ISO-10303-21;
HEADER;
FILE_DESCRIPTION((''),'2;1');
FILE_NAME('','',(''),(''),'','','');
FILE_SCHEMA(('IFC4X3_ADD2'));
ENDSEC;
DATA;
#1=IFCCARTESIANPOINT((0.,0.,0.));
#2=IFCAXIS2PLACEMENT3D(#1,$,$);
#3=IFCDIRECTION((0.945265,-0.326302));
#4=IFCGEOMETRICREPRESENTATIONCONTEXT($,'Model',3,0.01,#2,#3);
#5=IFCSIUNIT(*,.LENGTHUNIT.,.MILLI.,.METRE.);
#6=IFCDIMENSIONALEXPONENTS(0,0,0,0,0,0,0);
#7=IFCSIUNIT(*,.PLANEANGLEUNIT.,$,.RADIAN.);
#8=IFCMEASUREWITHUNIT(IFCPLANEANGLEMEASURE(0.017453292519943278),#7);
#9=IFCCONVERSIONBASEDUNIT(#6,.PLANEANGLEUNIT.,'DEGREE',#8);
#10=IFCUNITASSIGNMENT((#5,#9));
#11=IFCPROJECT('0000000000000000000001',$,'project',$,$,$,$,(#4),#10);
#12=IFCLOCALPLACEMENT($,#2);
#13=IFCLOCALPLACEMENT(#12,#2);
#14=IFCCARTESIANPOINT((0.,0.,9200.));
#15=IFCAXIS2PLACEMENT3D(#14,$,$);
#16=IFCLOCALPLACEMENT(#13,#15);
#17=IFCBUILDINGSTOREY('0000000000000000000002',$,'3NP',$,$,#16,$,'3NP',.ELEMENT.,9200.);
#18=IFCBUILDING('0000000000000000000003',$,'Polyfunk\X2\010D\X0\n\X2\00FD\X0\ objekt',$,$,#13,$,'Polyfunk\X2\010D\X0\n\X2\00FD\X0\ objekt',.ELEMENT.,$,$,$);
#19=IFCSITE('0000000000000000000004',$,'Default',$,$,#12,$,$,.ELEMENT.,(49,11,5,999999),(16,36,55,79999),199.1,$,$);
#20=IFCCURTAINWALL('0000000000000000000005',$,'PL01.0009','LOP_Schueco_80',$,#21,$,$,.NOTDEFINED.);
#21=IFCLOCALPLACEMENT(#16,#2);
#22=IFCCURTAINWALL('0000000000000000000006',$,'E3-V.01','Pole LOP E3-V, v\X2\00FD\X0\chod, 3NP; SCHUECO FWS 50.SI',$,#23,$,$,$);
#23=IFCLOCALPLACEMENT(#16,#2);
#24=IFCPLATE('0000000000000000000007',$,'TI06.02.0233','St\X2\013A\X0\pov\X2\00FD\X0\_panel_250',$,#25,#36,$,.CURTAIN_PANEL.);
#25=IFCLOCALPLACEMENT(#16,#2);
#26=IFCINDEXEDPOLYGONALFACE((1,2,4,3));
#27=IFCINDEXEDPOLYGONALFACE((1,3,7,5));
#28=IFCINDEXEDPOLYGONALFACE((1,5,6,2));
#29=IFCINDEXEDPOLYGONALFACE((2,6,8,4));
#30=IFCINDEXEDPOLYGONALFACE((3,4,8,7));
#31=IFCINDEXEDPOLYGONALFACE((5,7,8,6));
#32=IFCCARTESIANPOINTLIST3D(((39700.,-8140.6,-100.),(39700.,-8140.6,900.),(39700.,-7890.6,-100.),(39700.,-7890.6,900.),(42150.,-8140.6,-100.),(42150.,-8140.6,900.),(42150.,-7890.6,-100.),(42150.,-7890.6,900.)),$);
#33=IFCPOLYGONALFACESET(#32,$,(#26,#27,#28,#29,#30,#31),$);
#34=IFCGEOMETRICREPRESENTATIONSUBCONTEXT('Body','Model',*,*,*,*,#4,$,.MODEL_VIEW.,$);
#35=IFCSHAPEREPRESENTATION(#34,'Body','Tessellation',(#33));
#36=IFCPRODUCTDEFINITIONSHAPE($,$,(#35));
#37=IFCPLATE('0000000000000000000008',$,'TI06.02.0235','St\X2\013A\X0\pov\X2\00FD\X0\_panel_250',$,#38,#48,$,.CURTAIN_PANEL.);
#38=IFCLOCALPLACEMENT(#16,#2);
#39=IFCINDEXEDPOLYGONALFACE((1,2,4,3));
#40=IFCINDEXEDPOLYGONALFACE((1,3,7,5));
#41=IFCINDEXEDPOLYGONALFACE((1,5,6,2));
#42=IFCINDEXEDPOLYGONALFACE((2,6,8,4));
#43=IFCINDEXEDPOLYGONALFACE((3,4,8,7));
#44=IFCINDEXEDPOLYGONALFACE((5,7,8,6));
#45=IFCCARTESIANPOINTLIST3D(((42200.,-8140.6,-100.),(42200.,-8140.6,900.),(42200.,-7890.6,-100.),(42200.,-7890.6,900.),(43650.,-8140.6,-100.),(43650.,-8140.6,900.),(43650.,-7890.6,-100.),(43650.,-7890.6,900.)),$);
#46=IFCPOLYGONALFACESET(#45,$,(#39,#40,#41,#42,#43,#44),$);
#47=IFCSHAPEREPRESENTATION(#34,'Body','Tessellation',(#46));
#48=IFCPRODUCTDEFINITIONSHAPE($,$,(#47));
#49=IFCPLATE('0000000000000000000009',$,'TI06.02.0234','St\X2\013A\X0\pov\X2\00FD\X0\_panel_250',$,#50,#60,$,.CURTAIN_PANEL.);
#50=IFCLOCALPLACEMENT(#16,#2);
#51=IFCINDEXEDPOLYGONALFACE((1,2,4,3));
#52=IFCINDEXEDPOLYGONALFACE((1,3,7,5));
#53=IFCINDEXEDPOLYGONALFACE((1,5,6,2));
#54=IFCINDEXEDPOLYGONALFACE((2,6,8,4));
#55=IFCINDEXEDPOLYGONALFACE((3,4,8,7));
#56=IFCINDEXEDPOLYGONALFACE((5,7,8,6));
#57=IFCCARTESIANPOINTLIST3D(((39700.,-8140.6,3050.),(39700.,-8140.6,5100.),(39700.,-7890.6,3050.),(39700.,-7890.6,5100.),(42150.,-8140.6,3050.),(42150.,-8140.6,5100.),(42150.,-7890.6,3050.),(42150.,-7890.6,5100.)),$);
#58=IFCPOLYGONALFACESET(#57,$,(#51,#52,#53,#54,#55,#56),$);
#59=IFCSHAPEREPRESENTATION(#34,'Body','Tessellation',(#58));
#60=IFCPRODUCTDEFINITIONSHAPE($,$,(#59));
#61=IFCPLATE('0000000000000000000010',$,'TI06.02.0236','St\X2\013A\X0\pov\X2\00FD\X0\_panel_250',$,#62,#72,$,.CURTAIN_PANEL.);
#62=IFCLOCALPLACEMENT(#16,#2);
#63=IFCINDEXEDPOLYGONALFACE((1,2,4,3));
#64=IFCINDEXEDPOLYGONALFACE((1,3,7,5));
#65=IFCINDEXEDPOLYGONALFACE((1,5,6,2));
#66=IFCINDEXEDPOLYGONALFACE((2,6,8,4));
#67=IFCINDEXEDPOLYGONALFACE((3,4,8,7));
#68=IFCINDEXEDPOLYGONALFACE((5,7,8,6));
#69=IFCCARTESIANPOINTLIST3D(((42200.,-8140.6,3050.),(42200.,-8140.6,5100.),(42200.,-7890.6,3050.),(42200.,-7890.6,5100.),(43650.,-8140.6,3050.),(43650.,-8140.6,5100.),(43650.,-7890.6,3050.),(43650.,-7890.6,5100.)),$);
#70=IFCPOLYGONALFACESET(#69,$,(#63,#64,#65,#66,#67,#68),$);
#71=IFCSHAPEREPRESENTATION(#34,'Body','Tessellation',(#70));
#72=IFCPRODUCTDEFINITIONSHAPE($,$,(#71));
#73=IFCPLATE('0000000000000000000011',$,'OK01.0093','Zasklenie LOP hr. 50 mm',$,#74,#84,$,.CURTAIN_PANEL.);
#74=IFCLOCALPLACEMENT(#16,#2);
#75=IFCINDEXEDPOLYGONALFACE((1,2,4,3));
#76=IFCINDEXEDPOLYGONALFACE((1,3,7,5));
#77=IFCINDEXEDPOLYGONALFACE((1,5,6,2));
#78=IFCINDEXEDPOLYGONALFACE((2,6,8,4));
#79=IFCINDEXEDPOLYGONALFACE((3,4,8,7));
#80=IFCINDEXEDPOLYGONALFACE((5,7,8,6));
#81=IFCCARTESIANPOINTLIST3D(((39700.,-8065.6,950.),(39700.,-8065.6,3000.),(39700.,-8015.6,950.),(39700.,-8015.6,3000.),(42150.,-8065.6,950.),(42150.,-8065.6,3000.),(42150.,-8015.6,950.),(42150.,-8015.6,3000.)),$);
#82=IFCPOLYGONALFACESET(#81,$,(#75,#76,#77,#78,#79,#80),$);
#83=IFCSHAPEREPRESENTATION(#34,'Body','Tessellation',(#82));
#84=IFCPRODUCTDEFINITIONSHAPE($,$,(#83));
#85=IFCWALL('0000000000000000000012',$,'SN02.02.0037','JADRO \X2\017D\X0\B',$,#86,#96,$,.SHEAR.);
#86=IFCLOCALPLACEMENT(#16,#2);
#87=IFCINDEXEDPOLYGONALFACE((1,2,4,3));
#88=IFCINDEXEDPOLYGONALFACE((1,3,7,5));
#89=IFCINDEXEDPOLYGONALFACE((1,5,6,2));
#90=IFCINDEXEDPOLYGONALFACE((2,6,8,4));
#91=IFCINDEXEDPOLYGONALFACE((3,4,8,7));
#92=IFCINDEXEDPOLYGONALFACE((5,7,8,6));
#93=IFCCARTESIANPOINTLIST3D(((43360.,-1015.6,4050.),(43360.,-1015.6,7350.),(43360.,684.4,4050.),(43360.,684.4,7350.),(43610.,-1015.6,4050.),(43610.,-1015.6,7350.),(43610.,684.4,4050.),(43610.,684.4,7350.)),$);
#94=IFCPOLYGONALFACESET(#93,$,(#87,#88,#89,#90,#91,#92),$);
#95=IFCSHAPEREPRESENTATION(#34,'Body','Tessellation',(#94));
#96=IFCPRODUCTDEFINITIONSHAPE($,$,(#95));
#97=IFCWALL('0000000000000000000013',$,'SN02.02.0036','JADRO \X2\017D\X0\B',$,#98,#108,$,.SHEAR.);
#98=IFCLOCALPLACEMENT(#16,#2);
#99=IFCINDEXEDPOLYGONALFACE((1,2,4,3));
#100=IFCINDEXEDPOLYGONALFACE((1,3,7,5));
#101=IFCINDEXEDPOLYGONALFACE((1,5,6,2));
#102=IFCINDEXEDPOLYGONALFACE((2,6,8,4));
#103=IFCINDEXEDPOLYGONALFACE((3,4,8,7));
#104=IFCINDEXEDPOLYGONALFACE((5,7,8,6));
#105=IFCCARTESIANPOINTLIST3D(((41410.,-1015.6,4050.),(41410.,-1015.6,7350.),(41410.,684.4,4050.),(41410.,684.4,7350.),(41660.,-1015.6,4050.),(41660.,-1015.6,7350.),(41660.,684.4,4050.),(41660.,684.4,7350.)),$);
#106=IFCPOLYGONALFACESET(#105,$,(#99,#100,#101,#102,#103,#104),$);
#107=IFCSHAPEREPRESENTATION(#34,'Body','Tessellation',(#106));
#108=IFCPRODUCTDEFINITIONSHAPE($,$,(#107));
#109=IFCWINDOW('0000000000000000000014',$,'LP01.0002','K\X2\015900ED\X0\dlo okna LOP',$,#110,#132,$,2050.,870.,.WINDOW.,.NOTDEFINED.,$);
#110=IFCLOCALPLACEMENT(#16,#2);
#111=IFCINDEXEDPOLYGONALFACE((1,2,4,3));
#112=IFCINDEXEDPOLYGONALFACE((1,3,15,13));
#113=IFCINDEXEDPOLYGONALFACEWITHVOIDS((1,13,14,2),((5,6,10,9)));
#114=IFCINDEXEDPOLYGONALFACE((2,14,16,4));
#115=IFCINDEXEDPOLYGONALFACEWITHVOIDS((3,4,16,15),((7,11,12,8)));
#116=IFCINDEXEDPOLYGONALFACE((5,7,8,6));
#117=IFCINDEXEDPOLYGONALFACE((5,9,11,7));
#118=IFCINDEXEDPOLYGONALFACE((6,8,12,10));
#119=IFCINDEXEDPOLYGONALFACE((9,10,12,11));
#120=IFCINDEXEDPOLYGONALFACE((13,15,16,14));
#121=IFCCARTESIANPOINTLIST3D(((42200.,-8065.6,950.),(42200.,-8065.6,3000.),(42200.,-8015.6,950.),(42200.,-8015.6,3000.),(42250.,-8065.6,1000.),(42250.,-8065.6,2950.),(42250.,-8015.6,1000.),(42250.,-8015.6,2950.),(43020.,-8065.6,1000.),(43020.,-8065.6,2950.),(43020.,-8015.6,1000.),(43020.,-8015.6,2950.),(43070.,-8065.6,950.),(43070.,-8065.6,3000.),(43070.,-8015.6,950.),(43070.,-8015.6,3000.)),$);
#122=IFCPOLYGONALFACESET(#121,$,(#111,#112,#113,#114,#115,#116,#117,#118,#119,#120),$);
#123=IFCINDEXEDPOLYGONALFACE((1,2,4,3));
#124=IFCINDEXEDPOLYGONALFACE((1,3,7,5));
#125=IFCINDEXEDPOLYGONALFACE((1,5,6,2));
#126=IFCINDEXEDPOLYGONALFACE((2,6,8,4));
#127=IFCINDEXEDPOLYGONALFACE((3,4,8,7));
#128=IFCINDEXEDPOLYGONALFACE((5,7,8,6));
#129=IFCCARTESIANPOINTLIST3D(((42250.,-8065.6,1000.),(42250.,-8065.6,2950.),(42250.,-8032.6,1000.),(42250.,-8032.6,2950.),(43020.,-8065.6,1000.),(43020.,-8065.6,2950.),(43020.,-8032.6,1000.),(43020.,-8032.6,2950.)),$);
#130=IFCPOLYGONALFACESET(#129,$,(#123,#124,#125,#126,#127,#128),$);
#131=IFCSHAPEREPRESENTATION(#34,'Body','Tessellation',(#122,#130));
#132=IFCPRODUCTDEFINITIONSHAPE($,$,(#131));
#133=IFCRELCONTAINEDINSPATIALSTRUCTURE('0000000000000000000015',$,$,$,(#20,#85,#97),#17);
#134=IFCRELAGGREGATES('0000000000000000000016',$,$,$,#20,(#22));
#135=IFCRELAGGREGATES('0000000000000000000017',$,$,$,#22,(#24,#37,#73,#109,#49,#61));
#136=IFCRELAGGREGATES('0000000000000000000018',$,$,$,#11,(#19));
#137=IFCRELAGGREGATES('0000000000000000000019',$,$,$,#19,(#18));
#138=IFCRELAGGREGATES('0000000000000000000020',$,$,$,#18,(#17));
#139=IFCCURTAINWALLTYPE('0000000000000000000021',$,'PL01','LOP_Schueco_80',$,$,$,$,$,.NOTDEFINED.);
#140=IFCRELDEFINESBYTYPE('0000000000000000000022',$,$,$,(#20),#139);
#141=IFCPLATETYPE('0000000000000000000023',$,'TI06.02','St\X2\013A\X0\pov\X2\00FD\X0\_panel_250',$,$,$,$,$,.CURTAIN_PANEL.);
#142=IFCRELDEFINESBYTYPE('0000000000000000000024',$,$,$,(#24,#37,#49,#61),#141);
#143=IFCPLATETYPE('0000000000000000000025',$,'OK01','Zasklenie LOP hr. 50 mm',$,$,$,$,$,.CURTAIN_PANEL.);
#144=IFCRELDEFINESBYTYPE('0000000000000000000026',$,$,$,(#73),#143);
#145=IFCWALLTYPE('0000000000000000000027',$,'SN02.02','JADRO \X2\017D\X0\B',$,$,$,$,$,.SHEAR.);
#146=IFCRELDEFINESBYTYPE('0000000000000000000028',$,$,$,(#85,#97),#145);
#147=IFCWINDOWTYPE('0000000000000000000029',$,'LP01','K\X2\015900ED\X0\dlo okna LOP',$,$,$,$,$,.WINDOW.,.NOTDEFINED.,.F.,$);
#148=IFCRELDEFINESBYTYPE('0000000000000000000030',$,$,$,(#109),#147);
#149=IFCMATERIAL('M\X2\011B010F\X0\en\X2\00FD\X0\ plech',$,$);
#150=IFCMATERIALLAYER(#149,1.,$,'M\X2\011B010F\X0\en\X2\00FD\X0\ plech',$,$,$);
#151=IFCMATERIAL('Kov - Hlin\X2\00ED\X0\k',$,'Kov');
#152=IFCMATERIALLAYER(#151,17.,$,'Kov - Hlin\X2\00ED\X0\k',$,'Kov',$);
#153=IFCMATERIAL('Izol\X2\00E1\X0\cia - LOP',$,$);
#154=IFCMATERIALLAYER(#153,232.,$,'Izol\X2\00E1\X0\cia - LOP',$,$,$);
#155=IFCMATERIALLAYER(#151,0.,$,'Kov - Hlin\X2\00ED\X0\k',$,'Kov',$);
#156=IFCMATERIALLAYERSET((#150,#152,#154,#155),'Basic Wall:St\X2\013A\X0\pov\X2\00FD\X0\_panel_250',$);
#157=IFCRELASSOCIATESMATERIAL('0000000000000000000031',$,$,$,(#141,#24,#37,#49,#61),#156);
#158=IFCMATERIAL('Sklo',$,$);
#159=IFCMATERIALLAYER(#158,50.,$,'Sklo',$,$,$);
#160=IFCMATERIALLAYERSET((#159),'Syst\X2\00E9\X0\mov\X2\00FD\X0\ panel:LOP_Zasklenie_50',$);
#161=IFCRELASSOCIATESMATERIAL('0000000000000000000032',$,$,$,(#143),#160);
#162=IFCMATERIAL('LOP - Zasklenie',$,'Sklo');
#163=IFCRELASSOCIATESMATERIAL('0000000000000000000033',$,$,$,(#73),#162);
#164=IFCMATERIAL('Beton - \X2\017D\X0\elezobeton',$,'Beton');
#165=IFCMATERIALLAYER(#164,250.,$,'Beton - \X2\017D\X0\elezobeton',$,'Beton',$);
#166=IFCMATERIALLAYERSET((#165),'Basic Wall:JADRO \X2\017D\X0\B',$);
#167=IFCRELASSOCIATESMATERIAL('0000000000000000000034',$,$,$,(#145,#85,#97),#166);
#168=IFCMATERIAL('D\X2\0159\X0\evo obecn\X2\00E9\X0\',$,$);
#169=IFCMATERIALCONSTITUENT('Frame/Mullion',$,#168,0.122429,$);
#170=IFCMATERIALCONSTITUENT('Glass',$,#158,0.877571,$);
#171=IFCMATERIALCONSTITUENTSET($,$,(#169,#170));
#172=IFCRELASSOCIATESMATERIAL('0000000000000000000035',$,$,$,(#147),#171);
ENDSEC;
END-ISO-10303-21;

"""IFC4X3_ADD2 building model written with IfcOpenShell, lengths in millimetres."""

from ifc_helpers import new_model, entity, si_unit, converted_unit, direction, frame, frame_2d, origin, origin_2d_with_axis, place, context, subcontext, project, spatial, polyline, rectangle, outline, extrude, clip, bounded_halfspace, source, transform, mapped, material, layer, layer_set, layer_usage, constituent, constituent_set, type_object, type_shapes, element, aggregate, save


model = new_model("IFC4X3_ADD2")

# Units and contexts
model_context = context("Model", 3, precision=0.01, world=origin(), true_north=direction((0.945265, -0.326302)))
body_context = subcontext(model_context, "Body", "Model", "MODEL_VIEW")
ifc_project = project(units=[si_unit("LENGTHUNIT", "METRE", prefix="MILLI"), converted_unit("PLANEANGLEUNIT", "DEGREE", entity("IfcPlaneAngleMeasure", 0.017453292519943278), si_unit("PLANEANGLEUNIT", "RADIAN"), dimensions=[0, 0, 0, 0, 0, 0, 0])], contexts=[model_context])

# Site, building, storey
site_placement = place(None, origin())
site = spatial("IfcSite", under=ifc_project, at=site_placement, Name="Default", CompositionType="ELEMENT", RefLatitude=(49, 11, 5, 999999), RefLongitude=(16, 36, 55, 79999), RefElevation=199.1)
building_placement = place(site_placement, origin())
building = spatial("IfcBuilding", under=site, at=building_placement, Name="Polyfunkčný objekt", LongName="Polyfunkčný objekt", CompositionType="ELEMENT")
storey_placement = place(building_placement, frame((0.0, 0.0, 9200.0)))
storey = spatial("IfcBuildingStorey", under=building, at=storey_placement, Name="3NP", LongName="3NP", CompositionType="ELEMENT", Elevation=9200.0)

# Curtain walls, plates
curtain_wall_type = type_object("IfcCurtainWallType", Name="PL01", Description="LOP_Schueco_80", PredefinedType="NOTDEFINED")
curtain_wall_1_placement = place(storey_placement, frame((0.0, 0.0, -9200.0)))
curtain_wall_1 = element("IfcCurtainWall", 1, at=curtain_wall_1_placement, inside=storey, type_object=curtain_wall_type, Name="PL01.0009", Description="LOP_Schueco_80", PredefinedType="NOTDEFINED")
curtain_wall_2 = element("IfcCurtainWall", 2, Name="E3-V.01", Description="Pole LOP E3-V, východ, 3NP; SCHUECO FWS 50.SI")
aggregate(curtain_wall_1, [curtain_wall_2])
ifc_material_1 = material(Name="Měďený plech")
ifc_layer_1 = layer(ifc_material_1, 1.0, Name="Měďený plech")
ifc_material_2 = material(Name="Kov - Hliník", Category="Kov")
ifc_layer_2 = layer(ifc_material_2, 17.0, Name="Kov - Hliník", Category="Kov")
ifc_material_3 = material(Name="Izolácia - LOP")
ifc_layer_3 = layer(ifc_material_3, 232.0, Name="Izolácia - LOP")
ifc_layer_4 = layer(ifc_material_2, 0.0, Name="Kov - Hliník", Category="Kov")
ifc_layer_set_1 = layer_set([ifc_layer_1, ifc_layer_2, ifc_layer_3, ifc_layer_4], Name="Basic Wall:Stĺpový_panel_250")
ifc_layer_usage_1 = layer_usage(ifc_layer_set_1, "AXIS2", "POSITIVE", -125.0)
plate_type_1 = type_object("IfcPlateType", Name="TI06.02", Description="Stĺpový_panel_250", PredefinedType="CURTAIN_PANEL", material=ifc_layer_set_1)
plate_1_placement = place(storey_placement, frame((39700.0, -8015.6, -100.0)))
plate_1 = element("IfcPlate", 3, at=plate_1_placement, type_object=plate_type_1, material=ifc_layer_usage_1, Name="TI06.02.0233", Description="Stĺpový_panel_250", PredefinedType="CURTAIN_PANEL", context=body_context, shape_type="SweptSolid", body=[
    extrude(rectangle(XDim=250.0, YDim=2450.0, at=frame_2d((0.0, 0.0), x_axis=(1.0, 0.0))), frame((1225.0, 0.0, 0.0), z_axis=(0.0, 0.0, 1.0), x_axis=(0.0, 1.0, 0.0)), (0.0, 0.0, 1.0), 1000.0),
])
ifc_layer_usage_2 = layer_usage(ifc_layer_set_1, "AXIS2", "POSITIVE", -125.0)
plate_2_placement = place(storey_placement, frame((42200.0, -8015.6, -100.0)))
plate_2 = element("IfcPlate", 4, at=plate_2_placement, type_object=plate_type_1, material=ifc_layer_usage_2, Name="TI06.02.0235", Description="Stĺpový_panel_250", PredefinedType="CURTAIN_PANEL", context=body_context, shape_type="SweptSolid", body=[
    extrude(rectangle(XDim=250.0, YDim=1450.0, at=frame_2d((0.0, 0.0), x_axis=(1.0, 0.0))), frame((725.0, 0.0, 0.0), z_axis=(0.0, 0.0, 1.0), x_axis=(0.0, 1.0, 0.0)), (0.0, 0.0, 1.0), 1000.0),
])
ifc_layer_usage_3 = layer_usage(ifc_layer_set_1, "AXIS2", "POSITIVE", -125.0)
plate_3_placement = place(storey_placement, frame((39700.0, -8015.6, 3050.0)))
plate_3 = element("IfcPlate", 5, at=plate_3_placement, type_object=plate_type_1, material=ifc_layer_usage_3, Name="TI06.02.0234", Description="Stĺpový_panel_250", PredefinedType="CURTAIN_PANEL", context=body_context, shape_type="SweptSolid", body=[
    extrude(rectangle(XDim=250.0, YDim=2450.0, at=frame_2d((0.0, 0.0), x_axis=(1.0, 0.0))), frame((1225.0, 0.0, 0.0), z_axis=(0.0, 0.0, 1.0), x_axis=(0.0, 1.0, 0.0)), (0.0, 0.0, 1.0), 2050.0),
])
ifc_layer_usage_4 = layer_usage(ifc_layer_set_1, "AXIS2", "POSITIVE", -125.0)
plate_4_placement = place(storey_placement, frame((42200.0, -8015.6, 3050.0)))
plate_4 = element("IfcPlate", 6, at=plate_4_placement, type_object=plate_type_1, material=ifc_layer_usage_4, Name="TI06.02.0236", Description="Stĺpový_panel_250", PredefinedType="CURTAIN_PANEL", context=body_context, shape_type="SweptSolid", body=[
    extrude(rectangle(XDim=250.0, YDim=1450.0, at=frame_2d((0.0, 0.0), x_axis=(1.0, 0.0))), frame((725.0, 0.0, 0.0), z_axis=(0.0, 0.0, 1.0), x_axis=(0.0, 1.0, 0.0)), (0.0, 0.0, 1.0), 2050.0),
])
ifc_material_4 = material(Name="LOP - Zasklenie", Category="Sklo")
ifc_material_5 = material(Name="Sklo")
ifc_layer_5 = layer(ifc_material_5, 50.0, Name="Sklo")
ifc_layer_set_2 = layer_set([ifc_layer_5], Name="Systémový panel:LOP_Zasklenie_50")
plate_type_2 = type_object("IfcPlateType", Name="OK01", Description="Zasklenie LOP hr. 50 mm", PredefinedType="CURTAIN_PANEL", material=ifc_layer_set_2)
shared_shape_1 = source(origin(), body_context, "Body", "SweptSolid", [
    extrude(rectangle(XDim=50.0, YDim=2450.0, at=origin_2d_with_axis()), frame((0.0, -25.0, 0.0), z_axis=(0.0, 0.0, 1.0), x_axis=(0.0, 1.0, 0.0)), (0.0, 0.0, 1.0), 2050.0),
])
type_shapes(plate_type_2, [shared_shape_1])
plate_5_placement = place(curtain_wall_1_placement, frame((40925.0, -8015.6, 10150.0)))
plate_5 = element("IfcPlate", 7, at=plate_5_placement, type_object=plate_type_2, material=ifc_material_4, Name="OK01.0093", Description="Zasklenie LOP hr. 50 mm", PredefinedType="CURTAIN_PANEL", context=body_context, shape_type="MappedRepresentation", body=[
    mapped(shared_shape_1, transform((0.0, 0.0, 0.0), scale=1.0)),
])

# Walls
ifc_material_6 = material(Name="Beton - Železobeton", Category="Beton")
ifc_layer_6 = layer(ifc_material_6, 250.0, Name="Beton - Železobeton", Category="Beton")
ifc_layer_set_3 = layer_set([ifc_layer_6], Name="Basic Wall:JADRO ŽB")
wall_type = type_object("IfcWallType", Name="SN02.02", Description="JADRO ŽB", PredefinedType="SHEAR", material=ifc_layer_set_3)
wall_1_placement = place(storey_placement, frame((43485.0, 684.4, 4050.0), z_axis=(0.0, 0.0, 1.0), x_axis=(0.0, -1.0, 0.0)))
element("IfcWall", 8, at=wall_1_placement, inside=storey, type_object=wall_type, material=ifc_layer_set_3, Name="SN02.02.0037", Description="JADRO ŽB", PredefinedType="SHEAR", context=body_context, shape_type="Clipping", body=[
    clip(clip(extrude(rectangle(XDim=1700.0, YDim=250.0, at=frame_2d((850.0, 0.0), x_axis=(-1.0, 0.0))), origin(), (0.0, 0.0, 1.0), 3300.0), bounded_halfspace(frame((1700.0, -125.0, 0.0), z_axis=(0.0, 0.0, 1.0), x_axis=(0.0, -1.0, 0.0)), True, frame((1700.0, -125.0, 0.0)), polyline([(0.0, 0.0), (0.0, 250.0), (-1700.0, 250.0), (-1700.0, 0.0), (0.0, 0.0)]))), bounded_halfspace(frame((0.0, -125.0, 3300.0), z_axis=(0.0, 0.0, -1.0), x_axis=(1.0, 0.0, 0.0)), True, frame((0.0, -125.0, 3300.0)), polyline([(0.0, 0.0), (1700.0, 0.0), (1700.0, 250.0), (0.0, 250.0), (0.0, 0.0)]))),
])
wall_2_placement = place(storey_placement, frame((41535.0, 684.4, 4050.0), z_axis=(0.0, 0.0, 1.0), x_axis=(0.0, -1.0, 0.0)))
element("IfcWall", 9, at=wall_2_placement, inside=storey, type_object=wall_type, material=ifc_layer_set_3, Name="SN02.02.0036", Description="JADRO ŽB", PredefinedType="SHEAR", context=body_context, shape_type="Clipping", body=[
    clip(clip(extrude(rectangle(XDim=1700.0, YDim=250.0, at=frame_2d((850.0, 0.0), x_axis=(-1.0, 0.0))), origin(), (0.0, 0.0, 1.0), 3300.0), bounded_halfspace(frame((1700.0, -125.0, 0.0), z_axis=(0.0, 0.0, 1.0), x_axis=(0.0, -1.0, 0.0)), True, frame((1700.0, -125.0, 0.0)), polyline([(0.0, 0.0), (0.0, 250.0), (-1700.0, 250.0), (-1700.0, 0.0), (0.0, 0.0)]))), bounded_halfspace(frame((0.0, -125.0, 3300.0), z_axis=(0.0, 0.0, -1.0), x_axis=(1.0, 0.0, 0.0)), True, frame((0.0, -125.0, 3300.0)), polyline([(0.0, 0.0), (1700.0, 0.0), (1700.0, 250.0), (0.0, 250.0), (0.0, 0.0)]))),
])

# Window
ifc_material_7 = material(Name="Dřevo obecné")
ifc_constituent_1 = constituent(ifc_material_7, Name="Frame/Mullion", fraction=0.122429)
ifc_constituent_2 = constituent(ifc_material_5, Name="Glass", fraction=0.877571)
ifc_constituent_set = constituent_set(constituents=[ifc_constituent_1, ifc_constituent_2])
window_type = type_object("IfcWindowType", Name="LP01", Description="Křídlo okna LOP", ParameterTakesPrecedence=False, PartitioningType="NOTDEFINED", PredefinedType="WINDOW", material=ifc_constituent_set)
shared_shape_2 = source(origin(), body_context, "Body", "SweptSolid", [
    extrude(outline(polyline([(-1025.0, -435.0), (1025.0, -435.0), (1025.0, 435.0), (-1025.0, 435.0), (-1025.0, -435.0)]), holes=[polyline([(-975.0, -385.0), (-975.0, 385.0), (975.0, 385.0), (975.0, -385.0), (-975.0, -385.0)])]), frame((0.0, 50.0, 1025.0), z_axis=(0.0, -1.0, 0.0), x_axis=(0.0, 0.0, -1.0)), (0.0, 0.0, 1.0), 50.0),
    extrude(rectangle(XDim=770.0, YDim=33.0, at=frame_2d((0.0, 0.0), x_axis=(1.0, 0.0))), frame((0.0, 33.5, 50.0), z_axis=(0.0, 0.0, 1.0), x_axis=(-1.0, 0.0, 0.0)), (0.0, 0.0, 1.0), 1950.0),
])
type_shapes(window_type, [shared_shape_2])
window_placement = place(curtain_wall_1_placement, frame((42635.0, -8015.6, 10150.0), z_axis=(0.0, 0.0, 1.0), x_axis=(-1.0, 0.0, 0.0)))
window = element("IfcWindow", 10, at=window_placement, type_object=window_type, Name="LP01.0002", Description="Křídlo okna LOP", OverallHeight=2050.0, OverallWidth=870.0, PartitioningType="NOTDEFINED", PredefinedType="WINDOW", context=body_context, shape_type="MappedRepresentation", body=[
    mapped(shared_shape_2, transform((0.0, 0.0, 0.0), scale=1.0)),
])
aggregate(curtain_wall_2, [plate_1, plate_2, plate_5, window, plate_3, plate_4])

save(model, "model.ifc")
